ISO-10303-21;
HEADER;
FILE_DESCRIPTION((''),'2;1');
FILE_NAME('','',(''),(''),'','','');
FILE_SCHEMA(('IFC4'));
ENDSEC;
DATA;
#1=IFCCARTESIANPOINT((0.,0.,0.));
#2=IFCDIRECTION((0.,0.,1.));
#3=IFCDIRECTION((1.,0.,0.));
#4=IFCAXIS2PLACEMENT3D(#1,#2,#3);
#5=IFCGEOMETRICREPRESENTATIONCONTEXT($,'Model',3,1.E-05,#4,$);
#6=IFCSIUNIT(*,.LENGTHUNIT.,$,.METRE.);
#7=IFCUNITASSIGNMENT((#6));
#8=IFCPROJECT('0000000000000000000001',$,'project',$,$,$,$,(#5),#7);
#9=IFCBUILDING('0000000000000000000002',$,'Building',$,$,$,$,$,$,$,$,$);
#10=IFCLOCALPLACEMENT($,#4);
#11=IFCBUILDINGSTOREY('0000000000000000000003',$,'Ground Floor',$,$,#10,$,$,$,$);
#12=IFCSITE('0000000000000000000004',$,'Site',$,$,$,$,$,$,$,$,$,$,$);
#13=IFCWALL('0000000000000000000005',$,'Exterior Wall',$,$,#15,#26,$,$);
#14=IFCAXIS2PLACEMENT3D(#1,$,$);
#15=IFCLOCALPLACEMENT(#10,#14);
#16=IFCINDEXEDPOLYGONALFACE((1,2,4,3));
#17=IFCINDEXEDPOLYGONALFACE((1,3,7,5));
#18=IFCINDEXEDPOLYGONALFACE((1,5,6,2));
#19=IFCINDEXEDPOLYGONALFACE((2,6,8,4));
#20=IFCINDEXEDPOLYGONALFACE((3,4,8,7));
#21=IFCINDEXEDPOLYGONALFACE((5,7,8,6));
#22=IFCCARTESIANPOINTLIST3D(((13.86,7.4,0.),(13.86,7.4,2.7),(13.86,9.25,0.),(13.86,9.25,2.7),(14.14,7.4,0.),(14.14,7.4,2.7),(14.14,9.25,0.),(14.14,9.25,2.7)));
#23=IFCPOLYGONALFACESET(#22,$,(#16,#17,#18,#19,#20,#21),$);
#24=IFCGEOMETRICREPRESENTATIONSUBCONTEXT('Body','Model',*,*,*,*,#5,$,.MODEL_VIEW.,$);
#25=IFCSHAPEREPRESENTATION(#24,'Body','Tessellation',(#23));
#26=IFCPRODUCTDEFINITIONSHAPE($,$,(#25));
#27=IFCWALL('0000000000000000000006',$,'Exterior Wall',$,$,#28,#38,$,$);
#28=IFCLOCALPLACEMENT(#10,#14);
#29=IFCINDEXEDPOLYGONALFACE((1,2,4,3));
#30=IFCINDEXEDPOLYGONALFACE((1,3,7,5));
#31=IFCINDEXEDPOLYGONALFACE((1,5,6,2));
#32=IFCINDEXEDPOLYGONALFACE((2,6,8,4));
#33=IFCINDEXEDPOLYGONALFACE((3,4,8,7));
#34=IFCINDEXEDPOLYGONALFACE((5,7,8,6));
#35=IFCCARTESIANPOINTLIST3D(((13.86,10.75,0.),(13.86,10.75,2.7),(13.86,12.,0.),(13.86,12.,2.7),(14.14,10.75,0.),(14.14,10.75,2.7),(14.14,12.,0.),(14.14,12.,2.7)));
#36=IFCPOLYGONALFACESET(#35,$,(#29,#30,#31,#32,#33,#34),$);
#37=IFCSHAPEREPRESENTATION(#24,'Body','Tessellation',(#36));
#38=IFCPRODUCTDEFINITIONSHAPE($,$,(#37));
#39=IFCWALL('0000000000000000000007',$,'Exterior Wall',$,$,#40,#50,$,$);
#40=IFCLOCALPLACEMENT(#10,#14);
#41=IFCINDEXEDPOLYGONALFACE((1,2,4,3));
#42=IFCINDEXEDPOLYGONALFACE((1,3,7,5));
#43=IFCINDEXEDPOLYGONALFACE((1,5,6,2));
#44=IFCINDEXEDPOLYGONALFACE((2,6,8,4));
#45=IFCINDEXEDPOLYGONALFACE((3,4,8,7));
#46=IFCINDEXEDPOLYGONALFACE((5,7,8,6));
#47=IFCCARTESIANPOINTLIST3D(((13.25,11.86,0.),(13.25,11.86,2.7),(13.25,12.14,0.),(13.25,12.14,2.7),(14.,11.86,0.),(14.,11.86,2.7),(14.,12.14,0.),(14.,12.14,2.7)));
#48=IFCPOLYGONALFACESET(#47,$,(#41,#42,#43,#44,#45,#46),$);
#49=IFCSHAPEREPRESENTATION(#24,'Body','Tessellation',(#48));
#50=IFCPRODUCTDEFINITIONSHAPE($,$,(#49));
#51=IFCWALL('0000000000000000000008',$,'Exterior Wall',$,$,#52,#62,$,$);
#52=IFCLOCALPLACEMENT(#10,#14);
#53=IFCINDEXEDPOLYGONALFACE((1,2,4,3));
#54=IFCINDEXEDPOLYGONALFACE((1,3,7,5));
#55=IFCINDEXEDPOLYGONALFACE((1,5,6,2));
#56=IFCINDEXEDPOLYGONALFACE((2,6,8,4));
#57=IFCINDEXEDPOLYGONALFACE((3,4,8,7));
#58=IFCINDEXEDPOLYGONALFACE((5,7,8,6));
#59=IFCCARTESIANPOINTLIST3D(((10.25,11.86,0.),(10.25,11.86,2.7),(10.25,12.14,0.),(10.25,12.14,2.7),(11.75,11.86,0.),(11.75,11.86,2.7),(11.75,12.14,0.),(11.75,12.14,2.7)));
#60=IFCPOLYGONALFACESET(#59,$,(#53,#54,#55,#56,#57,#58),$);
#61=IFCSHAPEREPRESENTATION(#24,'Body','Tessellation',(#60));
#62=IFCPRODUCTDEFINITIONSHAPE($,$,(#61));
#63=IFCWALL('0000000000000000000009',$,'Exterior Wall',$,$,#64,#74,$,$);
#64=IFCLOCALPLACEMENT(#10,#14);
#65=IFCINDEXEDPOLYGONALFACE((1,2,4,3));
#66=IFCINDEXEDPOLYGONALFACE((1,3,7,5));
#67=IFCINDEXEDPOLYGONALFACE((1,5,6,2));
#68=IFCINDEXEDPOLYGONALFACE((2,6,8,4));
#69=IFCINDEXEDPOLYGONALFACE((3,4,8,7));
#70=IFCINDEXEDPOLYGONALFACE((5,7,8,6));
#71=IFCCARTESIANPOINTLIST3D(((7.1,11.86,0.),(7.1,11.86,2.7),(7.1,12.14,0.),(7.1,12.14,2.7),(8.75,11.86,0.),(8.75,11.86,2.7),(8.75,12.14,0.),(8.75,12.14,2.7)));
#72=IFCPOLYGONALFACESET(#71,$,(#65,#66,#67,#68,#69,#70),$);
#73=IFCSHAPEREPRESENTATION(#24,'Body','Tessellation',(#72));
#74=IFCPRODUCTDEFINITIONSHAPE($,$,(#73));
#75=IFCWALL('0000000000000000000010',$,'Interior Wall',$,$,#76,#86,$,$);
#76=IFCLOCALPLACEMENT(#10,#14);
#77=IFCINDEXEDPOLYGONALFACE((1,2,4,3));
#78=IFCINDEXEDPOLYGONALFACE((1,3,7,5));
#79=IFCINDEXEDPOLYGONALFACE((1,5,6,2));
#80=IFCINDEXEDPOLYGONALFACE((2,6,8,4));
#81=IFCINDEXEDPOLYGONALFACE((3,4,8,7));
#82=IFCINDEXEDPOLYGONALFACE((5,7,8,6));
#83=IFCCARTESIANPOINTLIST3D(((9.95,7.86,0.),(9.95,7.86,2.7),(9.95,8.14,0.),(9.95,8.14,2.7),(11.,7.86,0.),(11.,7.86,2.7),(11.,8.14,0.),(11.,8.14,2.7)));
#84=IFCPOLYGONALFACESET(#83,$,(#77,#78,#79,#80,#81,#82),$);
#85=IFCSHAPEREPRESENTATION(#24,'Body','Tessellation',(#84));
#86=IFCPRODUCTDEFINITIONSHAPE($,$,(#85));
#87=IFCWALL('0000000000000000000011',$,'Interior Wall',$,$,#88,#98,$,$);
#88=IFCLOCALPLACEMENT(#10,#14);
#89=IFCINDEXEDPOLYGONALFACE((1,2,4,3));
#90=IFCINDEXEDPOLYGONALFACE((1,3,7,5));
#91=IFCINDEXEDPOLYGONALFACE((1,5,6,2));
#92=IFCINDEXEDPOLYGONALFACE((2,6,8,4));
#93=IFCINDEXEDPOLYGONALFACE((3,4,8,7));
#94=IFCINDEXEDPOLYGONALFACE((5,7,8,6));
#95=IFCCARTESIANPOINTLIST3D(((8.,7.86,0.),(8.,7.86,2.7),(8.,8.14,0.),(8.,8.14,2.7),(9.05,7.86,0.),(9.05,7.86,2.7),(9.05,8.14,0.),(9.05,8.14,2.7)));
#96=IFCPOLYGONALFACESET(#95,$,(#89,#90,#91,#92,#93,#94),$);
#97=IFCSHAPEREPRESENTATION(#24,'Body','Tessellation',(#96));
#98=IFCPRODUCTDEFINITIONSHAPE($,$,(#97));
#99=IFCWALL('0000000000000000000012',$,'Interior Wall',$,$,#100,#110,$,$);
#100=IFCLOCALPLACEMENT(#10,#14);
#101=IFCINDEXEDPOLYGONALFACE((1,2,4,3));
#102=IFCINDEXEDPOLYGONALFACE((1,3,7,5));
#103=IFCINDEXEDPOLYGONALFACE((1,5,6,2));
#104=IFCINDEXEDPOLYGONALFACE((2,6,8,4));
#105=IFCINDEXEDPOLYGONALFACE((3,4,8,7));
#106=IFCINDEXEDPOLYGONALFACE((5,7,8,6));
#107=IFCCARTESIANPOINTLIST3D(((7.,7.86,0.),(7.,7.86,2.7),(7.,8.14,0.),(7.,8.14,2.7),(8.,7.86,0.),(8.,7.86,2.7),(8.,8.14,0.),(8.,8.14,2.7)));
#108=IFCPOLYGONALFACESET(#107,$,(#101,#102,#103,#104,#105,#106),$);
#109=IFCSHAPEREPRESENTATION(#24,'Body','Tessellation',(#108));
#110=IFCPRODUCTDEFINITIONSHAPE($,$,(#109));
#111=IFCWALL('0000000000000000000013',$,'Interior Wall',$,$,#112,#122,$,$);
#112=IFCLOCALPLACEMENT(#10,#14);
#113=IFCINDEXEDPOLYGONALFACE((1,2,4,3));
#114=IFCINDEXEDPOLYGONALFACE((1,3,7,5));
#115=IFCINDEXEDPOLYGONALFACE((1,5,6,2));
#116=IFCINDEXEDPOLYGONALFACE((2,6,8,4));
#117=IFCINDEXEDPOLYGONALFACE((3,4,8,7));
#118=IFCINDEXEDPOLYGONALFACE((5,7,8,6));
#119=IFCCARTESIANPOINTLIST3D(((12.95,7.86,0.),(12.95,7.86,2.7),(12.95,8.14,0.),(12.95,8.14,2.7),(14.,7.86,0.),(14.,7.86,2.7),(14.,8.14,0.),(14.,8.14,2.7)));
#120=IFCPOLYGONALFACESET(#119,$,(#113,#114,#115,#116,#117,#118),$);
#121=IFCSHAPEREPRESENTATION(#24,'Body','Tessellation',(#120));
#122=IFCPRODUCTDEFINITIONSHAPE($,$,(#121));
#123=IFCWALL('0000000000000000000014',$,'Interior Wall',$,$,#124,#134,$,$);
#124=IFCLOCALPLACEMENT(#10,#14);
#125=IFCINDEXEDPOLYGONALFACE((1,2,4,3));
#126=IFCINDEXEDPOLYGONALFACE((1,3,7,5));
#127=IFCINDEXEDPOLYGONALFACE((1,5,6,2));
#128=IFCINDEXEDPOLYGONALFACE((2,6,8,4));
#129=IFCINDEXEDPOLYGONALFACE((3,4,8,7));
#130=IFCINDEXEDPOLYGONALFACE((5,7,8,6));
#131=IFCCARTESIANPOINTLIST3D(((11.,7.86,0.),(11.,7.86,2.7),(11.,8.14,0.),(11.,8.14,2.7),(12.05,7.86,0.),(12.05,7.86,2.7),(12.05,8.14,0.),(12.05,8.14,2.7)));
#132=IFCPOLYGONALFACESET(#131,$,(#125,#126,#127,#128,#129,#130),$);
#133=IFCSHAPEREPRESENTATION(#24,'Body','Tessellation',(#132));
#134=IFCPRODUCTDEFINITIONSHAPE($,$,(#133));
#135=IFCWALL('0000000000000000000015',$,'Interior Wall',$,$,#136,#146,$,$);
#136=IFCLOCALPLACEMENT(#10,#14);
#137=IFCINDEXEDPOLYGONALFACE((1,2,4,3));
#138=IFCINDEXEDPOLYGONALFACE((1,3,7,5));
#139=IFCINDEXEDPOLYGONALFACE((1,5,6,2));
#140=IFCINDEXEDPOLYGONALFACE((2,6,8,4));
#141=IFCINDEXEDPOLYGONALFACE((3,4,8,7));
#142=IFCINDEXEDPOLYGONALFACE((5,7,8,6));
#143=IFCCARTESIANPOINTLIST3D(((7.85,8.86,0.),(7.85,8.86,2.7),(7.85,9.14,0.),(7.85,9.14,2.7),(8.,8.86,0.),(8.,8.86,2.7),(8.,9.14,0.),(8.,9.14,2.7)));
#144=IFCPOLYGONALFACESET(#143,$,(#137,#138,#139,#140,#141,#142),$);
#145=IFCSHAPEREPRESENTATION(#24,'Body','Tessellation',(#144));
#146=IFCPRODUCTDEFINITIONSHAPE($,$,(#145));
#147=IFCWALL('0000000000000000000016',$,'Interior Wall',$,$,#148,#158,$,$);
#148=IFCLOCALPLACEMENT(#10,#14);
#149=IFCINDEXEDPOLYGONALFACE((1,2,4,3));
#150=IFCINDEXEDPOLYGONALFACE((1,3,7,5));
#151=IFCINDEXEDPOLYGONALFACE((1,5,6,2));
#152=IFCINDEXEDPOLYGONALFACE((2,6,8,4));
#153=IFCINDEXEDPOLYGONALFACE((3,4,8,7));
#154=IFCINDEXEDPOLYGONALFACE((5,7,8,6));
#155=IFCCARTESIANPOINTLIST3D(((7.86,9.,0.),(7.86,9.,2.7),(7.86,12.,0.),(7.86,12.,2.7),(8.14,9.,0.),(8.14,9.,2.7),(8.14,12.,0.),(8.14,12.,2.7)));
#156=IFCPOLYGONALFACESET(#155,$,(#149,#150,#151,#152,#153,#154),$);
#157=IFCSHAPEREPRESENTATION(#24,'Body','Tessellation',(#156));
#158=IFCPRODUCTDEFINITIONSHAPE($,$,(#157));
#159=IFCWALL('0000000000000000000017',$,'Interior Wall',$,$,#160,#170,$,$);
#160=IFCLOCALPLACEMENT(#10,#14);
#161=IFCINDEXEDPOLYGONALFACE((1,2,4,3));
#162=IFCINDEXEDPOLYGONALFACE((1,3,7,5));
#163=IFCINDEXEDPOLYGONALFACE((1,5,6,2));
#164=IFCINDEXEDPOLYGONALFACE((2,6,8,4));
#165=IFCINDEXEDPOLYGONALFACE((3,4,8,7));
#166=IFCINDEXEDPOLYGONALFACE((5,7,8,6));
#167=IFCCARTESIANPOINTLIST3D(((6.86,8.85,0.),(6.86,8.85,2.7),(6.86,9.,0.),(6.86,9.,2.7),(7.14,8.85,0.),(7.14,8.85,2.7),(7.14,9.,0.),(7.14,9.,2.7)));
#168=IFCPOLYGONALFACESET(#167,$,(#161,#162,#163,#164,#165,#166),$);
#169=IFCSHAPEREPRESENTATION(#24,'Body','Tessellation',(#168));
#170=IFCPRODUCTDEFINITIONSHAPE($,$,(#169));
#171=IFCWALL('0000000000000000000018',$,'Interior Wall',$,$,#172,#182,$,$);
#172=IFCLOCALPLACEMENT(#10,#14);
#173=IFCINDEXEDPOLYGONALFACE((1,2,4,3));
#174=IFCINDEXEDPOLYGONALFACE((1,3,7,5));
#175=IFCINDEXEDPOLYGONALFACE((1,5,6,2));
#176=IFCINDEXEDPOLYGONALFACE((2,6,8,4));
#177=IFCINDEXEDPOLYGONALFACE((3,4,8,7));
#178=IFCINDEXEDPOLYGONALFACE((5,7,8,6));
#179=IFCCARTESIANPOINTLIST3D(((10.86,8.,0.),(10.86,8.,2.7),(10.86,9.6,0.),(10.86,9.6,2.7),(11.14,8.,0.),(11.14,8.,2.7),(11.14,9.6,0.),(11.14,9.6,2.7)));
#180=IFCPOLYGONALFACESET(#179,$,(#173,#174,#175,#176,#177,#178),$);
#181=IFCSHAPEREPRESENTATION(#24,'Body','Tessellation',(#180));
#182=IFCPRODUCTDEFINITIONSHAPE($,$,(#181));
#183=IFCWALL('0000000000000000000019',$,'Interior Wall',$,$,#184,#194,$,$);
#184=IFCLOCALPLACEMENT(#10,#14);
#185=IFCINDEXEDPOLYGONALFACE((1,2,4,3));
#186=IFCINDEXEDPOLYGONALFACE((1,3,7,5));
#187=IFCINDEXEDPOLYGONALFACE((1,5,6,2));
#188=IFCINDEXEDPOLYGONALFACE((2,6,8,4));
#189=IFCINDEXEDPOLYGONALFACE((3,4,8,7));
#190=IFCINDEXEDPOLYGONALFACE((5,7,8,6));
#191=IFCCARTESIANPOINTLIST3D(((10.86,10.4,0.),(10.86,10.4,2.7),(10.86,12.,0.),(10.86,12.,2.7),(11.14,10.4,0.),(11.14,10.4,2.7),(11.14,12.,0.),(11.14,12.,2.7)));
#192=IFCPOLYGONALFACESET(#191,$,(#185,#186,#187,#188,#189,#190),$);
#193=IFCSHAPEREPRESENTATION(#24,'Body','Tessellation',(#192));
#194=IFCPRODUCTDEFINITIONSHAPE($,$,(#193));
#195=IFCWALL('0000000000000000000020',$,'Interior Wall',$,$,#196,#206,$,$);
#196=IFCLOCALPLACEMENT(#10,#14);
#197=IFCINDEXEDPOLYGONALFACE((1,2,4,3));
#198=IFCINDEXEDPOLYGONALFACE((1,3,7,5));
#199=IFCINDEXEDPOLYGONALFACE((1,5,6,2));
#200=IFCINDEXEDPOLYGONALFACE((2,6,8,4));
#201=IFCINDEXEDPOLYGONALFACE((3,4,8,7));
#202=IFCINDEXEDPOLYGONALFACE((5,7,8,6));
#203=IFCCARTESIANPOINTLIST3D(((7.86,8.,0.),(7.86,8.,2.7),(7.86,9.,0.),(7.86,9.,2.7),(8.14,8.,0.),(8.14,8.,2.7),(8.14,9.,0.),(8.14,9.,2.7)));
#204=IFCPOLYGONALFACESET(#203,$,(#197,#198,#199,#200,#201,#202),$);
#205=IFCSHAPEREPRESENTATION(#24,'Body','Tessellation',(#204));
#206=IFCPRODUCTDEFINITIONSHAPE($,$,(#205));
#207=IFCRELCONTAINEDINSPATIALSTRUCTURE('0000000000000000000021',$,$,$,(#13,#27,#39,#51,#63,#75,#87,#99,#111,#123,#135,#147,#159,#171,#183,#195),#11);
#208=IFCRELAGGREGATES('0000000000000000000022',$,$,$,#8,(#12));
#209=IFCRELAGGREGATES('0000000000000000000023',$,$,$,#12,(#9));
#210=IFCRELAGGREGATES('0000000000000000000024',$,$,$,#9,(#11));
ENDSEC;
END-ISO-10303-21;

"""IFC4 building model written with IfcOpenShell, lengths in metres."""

from ifc_helpers import new_model, si_unit, frame, origin_with_axes, place, context, subcontext, project, spatial, indexed_curve, outline, extrude, element, save


model = new_model("IFC4")

# Units and contexts
model_context = context("Model", 3, precision=1e-05, world=origin_with_axes())
body_context = subcontext(model_context, "Body", "Model", "MODEL_VIEW")
ifc_project = project(units=[si_unit("LENGTHUNIT", "METRE")], contexts=[model_context])

# Site, building, storey
site = spatial("IfcSite", under=ifc_project, Name="Site")
building = spatial("IfcBuilding", under=site, Name="Building")
storey_placement = place(None, origin_with_axes())
storey = spatial("IfcBuildingStorey", under=building, at=storey_placement, Name="Ground Floor")

# Walls
wall_1_placement = place(storey_placement, frame((14.0, 7.4, 0.0), z_axis=(0.0, 0.0, 1.0), x_axis=(0.0, 1.0, 0.0)))
element("IfcWall", 1, at=wall_1_placement, inside=storey, Name="Exterior Wall", context=body_context, shape_type="SweptSolid", body=[
    extrude(outline(indexed_curve([(0.0, 0.0), (0.0, 0.28), (1.85, 0.28), (1.85, 0.0), (0.0, 0.0)], self_intersect=False)), frame((0.0, -0.14, 0.0), z_axis=(0.0, 0.0, 1.0), x_axis=(1.0, 0.0, 0.0)), (0.0, 0.0, 1.0), 2.7),
])
wall_2_placement = place(storey_placement, frame((14.0, 10.75, 0.0), z_axis=(0.0, 0.0, 1.0), x_axis=(0.0, 1.0, 0.0)))
element("IfcWall", 2, at=wall_2_placement, inside=storey, Name="Exterior Wall", context=body_context, shape_type="SweptSolid", body=[
    extrude(outline(indexed_curve([(0.0, 0.0), (0.0, 0.28), (1.25, 0.28), (1.25, 0.0), (0.0, 0.0)], self_intersect=False)), frame((0.0, -0.14, 0.0), z_axis=(0.0, 0.0, 1.0), x_axis=(1.0, 0.0, 0.0)), (0.0, 0.0, 1.0), 2.7),
])
wall_3_placement = place(storey_placement, frame((14.0, 12.0, 0.0), z_axis=(0.0, 0.0, 1.0), x_axis=(-1.0, 0.0, 0.0)))
element("IfcWall", 3, at=wall_3_placement, inside=storey, Name="Exterior Wall", context=body_context, shape_type="SweptSolid", body=[
    extrude(outline(indexed_curve([(0.0, 0.0), (0.0, 0.28), (0.75, 0.28), (0.75, 0.0), (0.0, 0.0)], self_intersect=False)), frame((0.0, -0.14, 0.0), z_axis=(0.0, 0.0, 1.0), x_axis=(1.0, 0.0, 0.0)), (0.0, 0.0, 1.0), 2.7),
])
wall_4_placement = place(storey_placement, frame((11.75, 12.0, 0.0), z_axis=(0.0, 0.0, 1.0), x_axis=(-1.0, 0.0, 0.0)))
element("IfcWall", 4, at=wall_4_placement, inside=storey, Name="Exterior Wall", context=body_context, shape_type="SweptSolid", body=[
    extrude(outline(indexed_curve([(0.0, 0.0), (0.0, 0.28), (1.5, 0.28), (1.5, 0.0), (0.0, 0.0)], self_intersect=False)), frame((0.0, -0.14, 0.0), z_axis=(0.0, 0.0, 1.0), x_axis=(1.0, 0.0, 0.0)), (0.0, 0.0, 1.0), 2.7),
])
wall_5_placement = place(storey_placement, frame((8.75, 12.0, 0.0), z_axis=(0.0, 0.0, 1.0), x_axis=(-1.0, 0.0, 0.0)))
element("IfcWall", 5, at=wall_5_placement, inside=storey, Name="Exterior Wall", context=body_context, shape_type="SweptSolid", body=[
    extrude(outline(indexed_curve([(0.0, 0.0), (0.0, 0.28), (1.65, 0.28), (1.65, 0.0), (0.0, 0.0)], self_intersect=False)), frame((0.0, -0.14, 0.0), z_axis=(0.0, 0.0, 1.0), x_axis=(1.0, 0.0, 0.0)), (0.0, 0.0, 1.0), 2.7),
])
for number, where, z_axis, x_axis, name in (
    (6, (11.0, 8.0, 0.0), (0.0, 0.0, 1.0), (-1.0, 0.0, 0.0), "Interior Wall"),
    (7, (9.05, 8.0, 0.0), (0.0, 0.0, 1.0), (-1.0, 0.0, 0.0), "Interior Wall"),
):
    element("IfcWall", number, at=place(storey_placement, frame(where, z_axis=z_axis, x_axis=x_axis)), inside=storey, Name=name, context=body_context, shape_type="SweptSolid", body=[
        extrude(outline(indexed_curve([(0.0, 0.0), (0.0, 0.28), (1.05, 0.28), (1.05, 0.0), (0.0, 0.0)], self_intersect=False)), frame((0.0, -0.14, 0.0), z_axis=(0.0, 0.0, 1.0), x_axis=(1.0, 0.0, 0.0)), (0.0, 0.0, 1.0), 2.7),
    ])
wall_6_placement = place(storey_placement, frame((8.0, 8.0, 0.0), z_axis=(0.0, 0.0, 1.0), x_axis=(-1.0, 0.0, 0.0)))
element("IfcWall", 8, at=wall_6_placement, inside=storey, Name="Interior Wall", context=body_context, shape_type="SweptSolid", body=[
    extrude(outline(indexed_curve([(0.0, 0.0), (0.0, 0.28), (1.0, 0.28), (1.0, 0.0), (0.0, 0.0)], self_intersect=False)), frame((0.0, -0.14, 0.0), z_axis=(0.0, 0.0, 1.0), x_axis=(1.0, 0.0, 0.0)), (0.0, 0.0, 1.0), 2.7),
])
for number, where, z_axis, x_axis, name in (
    (9, (14.0, 8.0, 0.0), (0.0, 0.0, 1.0), (-1.0, 0.0, 0.0), "Interior Wall"),
    (10, (12.05, 8.0, 0.0), (0.0, 0.0, 1.0), (-1.0, 0.0, 0.0), "Interior Wall"),
):
    element("IfcWall", number, at=place(storey_placement, frame(where, z_axis=z_axis, x_axis=x_axis)), inside=storey, Name=name, context=body_context, shape_type="SweptSolid", body=[
        extrude(outline(indexed_curve([(0.0, 0.0), (0.0, 0.28), (1.05, 0.28), (1.05, 0.0), (0.0, 0.0)], self_intersect=False)), frame((0.0, -0.14, 0.0), z_axis=(0.0, 0.0, 1.0), x_axis=(1.0, 0.0, 0.0)), (0.0, 0.0, 1.0), 2.7),
    ])
wall_7_placement = place(storey_placement, frame((7.85, 9.0, 0.0), z_axis=(0.0, 0.0, 1.0), x_axis=(1.0, 0.0, 0.0)))
element("IfcWall", 11, at=wall_7_placement, inside=storey, Name="Interior Wall", context=body_context, shape_type="SweptSolid", body=[
    extrude(outline(indexed_curve([(0.0, 0.0), (0.0, 0.28), (0.15, 0.28), (0.15, 0.0), (0.0, 0.0)], self_intersect=False)), frame((0.0, -0.14, 0.0), z_axis=(0.0, 0.0, 1.0), x_axis=(1.0, 0.0, 0.0)), (0.0, 0.0, 1.0), 2.7),
])
wall_8_placement = place(storey_placement, frame((8.0, 9.0, 0.0), z_axis=(0.0, 0.0, 1.0), x_axis=(0.0, 1.0, 0.0)))
element("IfcWall", 12, at=wall_8_placement, inside=storey, Name="Interior Wall", context=body_context, shape_type="SweptSolid", body=[
    extrude(outline(indexed_curve([(0.0, 0.0), (0.0, 0.28), (3.0, 0.28), (3.0, 0.0), (0.0, 0.0)], self_intersect=False)), frame((0.0, -0.14, 0.0), z_axis=(0.0, 0.0, 1.0), x_axis=(1.0, 0.0, 0.0)), (0.0, 0.0, 1.0), 2.7),
])
wall_9_placement = place(storey_placement, frame((7.0, 8.85, 0.0), z_axis=(0.0, 0.0, 1.0), x_axis=(0.0, 1.0, 0.0)))
element("IfcWall", 13, at=wall_9_placement, inside=storey, Name="Interior Wall", context=body_context, shape_type="SweptSolid", body=[
    extrude(outline(indexed_curve([(0.0, 0.0), (0.0, 0.28), (0.15, 0.28), (0.15, 0.0), (0.0, 0.0)], self_intersect=False)), frame((0.0, -0.14, 0.0), z_axis=(0.0, 0.0, 1.0), x_axis=(1.0, 0.0, 0.0)), (0.0, 0.0, 1.0), 2.7),
])
for number, where, z_axis, x_axis, name in (
    (14, (11.0, 8.0, 0.0), (0.0, 0.0, 1.0), (0.0, 1.0, 0.0), "Interior Wall"),
    (15, (11.0, 10.4, 0.0), (0.0, 0.0, 1.0), (0.0, 1.0, 0.0), "Interior Wall"),
):
    element("IfcWall", number, at=place(storey_placement, frame(where, z_axis=z_axis, x_axis=x_axis)), inside=storey, Name=name, context=body_context, shape_type="SweptSolid", body=[
        extrude(outline(indexed_curve([(0.0, 0.0), (0.0, 0.28), (1.6, 0.28), (1.6, 0.0), (0.0, 0.0)], self_intersect=False)), frame((0.0, -0.14, 0.0), z_axis=(0.0, 0.0, 1.0), x_axis=(1.0, 0.0, 0.0)), (0.0, 0.0, 1.0), 2.7),
    ])
wall_10_placement = place(storey_placement, frame((8.0, 9.0, 0.0), z_axis=(0.0, 0.0, 1.0), x_axis=(0.0, -1.0, 0.0)))
element("IfcWall", 16, at=wall_10_placement, inside=storey, Name="Interior Wall", context=body_context, shape_type="SweptSolid", body=[
    extrude(outline(indexed_curve([(0.0, 0.0), (0.0, 0.28), (1.0, 0.28), (1.0, 0.0), (0.0, 0.0)], self_intersect=False)), frame((0.0, -0.14, 0.0), z_axis=(0.0, 0.0, 1.0), x_axis=(1.0, 0.0, 0.0)), (0.0, 0.0, 1.0), 2.7),
])

save(model, "model.ifc")
